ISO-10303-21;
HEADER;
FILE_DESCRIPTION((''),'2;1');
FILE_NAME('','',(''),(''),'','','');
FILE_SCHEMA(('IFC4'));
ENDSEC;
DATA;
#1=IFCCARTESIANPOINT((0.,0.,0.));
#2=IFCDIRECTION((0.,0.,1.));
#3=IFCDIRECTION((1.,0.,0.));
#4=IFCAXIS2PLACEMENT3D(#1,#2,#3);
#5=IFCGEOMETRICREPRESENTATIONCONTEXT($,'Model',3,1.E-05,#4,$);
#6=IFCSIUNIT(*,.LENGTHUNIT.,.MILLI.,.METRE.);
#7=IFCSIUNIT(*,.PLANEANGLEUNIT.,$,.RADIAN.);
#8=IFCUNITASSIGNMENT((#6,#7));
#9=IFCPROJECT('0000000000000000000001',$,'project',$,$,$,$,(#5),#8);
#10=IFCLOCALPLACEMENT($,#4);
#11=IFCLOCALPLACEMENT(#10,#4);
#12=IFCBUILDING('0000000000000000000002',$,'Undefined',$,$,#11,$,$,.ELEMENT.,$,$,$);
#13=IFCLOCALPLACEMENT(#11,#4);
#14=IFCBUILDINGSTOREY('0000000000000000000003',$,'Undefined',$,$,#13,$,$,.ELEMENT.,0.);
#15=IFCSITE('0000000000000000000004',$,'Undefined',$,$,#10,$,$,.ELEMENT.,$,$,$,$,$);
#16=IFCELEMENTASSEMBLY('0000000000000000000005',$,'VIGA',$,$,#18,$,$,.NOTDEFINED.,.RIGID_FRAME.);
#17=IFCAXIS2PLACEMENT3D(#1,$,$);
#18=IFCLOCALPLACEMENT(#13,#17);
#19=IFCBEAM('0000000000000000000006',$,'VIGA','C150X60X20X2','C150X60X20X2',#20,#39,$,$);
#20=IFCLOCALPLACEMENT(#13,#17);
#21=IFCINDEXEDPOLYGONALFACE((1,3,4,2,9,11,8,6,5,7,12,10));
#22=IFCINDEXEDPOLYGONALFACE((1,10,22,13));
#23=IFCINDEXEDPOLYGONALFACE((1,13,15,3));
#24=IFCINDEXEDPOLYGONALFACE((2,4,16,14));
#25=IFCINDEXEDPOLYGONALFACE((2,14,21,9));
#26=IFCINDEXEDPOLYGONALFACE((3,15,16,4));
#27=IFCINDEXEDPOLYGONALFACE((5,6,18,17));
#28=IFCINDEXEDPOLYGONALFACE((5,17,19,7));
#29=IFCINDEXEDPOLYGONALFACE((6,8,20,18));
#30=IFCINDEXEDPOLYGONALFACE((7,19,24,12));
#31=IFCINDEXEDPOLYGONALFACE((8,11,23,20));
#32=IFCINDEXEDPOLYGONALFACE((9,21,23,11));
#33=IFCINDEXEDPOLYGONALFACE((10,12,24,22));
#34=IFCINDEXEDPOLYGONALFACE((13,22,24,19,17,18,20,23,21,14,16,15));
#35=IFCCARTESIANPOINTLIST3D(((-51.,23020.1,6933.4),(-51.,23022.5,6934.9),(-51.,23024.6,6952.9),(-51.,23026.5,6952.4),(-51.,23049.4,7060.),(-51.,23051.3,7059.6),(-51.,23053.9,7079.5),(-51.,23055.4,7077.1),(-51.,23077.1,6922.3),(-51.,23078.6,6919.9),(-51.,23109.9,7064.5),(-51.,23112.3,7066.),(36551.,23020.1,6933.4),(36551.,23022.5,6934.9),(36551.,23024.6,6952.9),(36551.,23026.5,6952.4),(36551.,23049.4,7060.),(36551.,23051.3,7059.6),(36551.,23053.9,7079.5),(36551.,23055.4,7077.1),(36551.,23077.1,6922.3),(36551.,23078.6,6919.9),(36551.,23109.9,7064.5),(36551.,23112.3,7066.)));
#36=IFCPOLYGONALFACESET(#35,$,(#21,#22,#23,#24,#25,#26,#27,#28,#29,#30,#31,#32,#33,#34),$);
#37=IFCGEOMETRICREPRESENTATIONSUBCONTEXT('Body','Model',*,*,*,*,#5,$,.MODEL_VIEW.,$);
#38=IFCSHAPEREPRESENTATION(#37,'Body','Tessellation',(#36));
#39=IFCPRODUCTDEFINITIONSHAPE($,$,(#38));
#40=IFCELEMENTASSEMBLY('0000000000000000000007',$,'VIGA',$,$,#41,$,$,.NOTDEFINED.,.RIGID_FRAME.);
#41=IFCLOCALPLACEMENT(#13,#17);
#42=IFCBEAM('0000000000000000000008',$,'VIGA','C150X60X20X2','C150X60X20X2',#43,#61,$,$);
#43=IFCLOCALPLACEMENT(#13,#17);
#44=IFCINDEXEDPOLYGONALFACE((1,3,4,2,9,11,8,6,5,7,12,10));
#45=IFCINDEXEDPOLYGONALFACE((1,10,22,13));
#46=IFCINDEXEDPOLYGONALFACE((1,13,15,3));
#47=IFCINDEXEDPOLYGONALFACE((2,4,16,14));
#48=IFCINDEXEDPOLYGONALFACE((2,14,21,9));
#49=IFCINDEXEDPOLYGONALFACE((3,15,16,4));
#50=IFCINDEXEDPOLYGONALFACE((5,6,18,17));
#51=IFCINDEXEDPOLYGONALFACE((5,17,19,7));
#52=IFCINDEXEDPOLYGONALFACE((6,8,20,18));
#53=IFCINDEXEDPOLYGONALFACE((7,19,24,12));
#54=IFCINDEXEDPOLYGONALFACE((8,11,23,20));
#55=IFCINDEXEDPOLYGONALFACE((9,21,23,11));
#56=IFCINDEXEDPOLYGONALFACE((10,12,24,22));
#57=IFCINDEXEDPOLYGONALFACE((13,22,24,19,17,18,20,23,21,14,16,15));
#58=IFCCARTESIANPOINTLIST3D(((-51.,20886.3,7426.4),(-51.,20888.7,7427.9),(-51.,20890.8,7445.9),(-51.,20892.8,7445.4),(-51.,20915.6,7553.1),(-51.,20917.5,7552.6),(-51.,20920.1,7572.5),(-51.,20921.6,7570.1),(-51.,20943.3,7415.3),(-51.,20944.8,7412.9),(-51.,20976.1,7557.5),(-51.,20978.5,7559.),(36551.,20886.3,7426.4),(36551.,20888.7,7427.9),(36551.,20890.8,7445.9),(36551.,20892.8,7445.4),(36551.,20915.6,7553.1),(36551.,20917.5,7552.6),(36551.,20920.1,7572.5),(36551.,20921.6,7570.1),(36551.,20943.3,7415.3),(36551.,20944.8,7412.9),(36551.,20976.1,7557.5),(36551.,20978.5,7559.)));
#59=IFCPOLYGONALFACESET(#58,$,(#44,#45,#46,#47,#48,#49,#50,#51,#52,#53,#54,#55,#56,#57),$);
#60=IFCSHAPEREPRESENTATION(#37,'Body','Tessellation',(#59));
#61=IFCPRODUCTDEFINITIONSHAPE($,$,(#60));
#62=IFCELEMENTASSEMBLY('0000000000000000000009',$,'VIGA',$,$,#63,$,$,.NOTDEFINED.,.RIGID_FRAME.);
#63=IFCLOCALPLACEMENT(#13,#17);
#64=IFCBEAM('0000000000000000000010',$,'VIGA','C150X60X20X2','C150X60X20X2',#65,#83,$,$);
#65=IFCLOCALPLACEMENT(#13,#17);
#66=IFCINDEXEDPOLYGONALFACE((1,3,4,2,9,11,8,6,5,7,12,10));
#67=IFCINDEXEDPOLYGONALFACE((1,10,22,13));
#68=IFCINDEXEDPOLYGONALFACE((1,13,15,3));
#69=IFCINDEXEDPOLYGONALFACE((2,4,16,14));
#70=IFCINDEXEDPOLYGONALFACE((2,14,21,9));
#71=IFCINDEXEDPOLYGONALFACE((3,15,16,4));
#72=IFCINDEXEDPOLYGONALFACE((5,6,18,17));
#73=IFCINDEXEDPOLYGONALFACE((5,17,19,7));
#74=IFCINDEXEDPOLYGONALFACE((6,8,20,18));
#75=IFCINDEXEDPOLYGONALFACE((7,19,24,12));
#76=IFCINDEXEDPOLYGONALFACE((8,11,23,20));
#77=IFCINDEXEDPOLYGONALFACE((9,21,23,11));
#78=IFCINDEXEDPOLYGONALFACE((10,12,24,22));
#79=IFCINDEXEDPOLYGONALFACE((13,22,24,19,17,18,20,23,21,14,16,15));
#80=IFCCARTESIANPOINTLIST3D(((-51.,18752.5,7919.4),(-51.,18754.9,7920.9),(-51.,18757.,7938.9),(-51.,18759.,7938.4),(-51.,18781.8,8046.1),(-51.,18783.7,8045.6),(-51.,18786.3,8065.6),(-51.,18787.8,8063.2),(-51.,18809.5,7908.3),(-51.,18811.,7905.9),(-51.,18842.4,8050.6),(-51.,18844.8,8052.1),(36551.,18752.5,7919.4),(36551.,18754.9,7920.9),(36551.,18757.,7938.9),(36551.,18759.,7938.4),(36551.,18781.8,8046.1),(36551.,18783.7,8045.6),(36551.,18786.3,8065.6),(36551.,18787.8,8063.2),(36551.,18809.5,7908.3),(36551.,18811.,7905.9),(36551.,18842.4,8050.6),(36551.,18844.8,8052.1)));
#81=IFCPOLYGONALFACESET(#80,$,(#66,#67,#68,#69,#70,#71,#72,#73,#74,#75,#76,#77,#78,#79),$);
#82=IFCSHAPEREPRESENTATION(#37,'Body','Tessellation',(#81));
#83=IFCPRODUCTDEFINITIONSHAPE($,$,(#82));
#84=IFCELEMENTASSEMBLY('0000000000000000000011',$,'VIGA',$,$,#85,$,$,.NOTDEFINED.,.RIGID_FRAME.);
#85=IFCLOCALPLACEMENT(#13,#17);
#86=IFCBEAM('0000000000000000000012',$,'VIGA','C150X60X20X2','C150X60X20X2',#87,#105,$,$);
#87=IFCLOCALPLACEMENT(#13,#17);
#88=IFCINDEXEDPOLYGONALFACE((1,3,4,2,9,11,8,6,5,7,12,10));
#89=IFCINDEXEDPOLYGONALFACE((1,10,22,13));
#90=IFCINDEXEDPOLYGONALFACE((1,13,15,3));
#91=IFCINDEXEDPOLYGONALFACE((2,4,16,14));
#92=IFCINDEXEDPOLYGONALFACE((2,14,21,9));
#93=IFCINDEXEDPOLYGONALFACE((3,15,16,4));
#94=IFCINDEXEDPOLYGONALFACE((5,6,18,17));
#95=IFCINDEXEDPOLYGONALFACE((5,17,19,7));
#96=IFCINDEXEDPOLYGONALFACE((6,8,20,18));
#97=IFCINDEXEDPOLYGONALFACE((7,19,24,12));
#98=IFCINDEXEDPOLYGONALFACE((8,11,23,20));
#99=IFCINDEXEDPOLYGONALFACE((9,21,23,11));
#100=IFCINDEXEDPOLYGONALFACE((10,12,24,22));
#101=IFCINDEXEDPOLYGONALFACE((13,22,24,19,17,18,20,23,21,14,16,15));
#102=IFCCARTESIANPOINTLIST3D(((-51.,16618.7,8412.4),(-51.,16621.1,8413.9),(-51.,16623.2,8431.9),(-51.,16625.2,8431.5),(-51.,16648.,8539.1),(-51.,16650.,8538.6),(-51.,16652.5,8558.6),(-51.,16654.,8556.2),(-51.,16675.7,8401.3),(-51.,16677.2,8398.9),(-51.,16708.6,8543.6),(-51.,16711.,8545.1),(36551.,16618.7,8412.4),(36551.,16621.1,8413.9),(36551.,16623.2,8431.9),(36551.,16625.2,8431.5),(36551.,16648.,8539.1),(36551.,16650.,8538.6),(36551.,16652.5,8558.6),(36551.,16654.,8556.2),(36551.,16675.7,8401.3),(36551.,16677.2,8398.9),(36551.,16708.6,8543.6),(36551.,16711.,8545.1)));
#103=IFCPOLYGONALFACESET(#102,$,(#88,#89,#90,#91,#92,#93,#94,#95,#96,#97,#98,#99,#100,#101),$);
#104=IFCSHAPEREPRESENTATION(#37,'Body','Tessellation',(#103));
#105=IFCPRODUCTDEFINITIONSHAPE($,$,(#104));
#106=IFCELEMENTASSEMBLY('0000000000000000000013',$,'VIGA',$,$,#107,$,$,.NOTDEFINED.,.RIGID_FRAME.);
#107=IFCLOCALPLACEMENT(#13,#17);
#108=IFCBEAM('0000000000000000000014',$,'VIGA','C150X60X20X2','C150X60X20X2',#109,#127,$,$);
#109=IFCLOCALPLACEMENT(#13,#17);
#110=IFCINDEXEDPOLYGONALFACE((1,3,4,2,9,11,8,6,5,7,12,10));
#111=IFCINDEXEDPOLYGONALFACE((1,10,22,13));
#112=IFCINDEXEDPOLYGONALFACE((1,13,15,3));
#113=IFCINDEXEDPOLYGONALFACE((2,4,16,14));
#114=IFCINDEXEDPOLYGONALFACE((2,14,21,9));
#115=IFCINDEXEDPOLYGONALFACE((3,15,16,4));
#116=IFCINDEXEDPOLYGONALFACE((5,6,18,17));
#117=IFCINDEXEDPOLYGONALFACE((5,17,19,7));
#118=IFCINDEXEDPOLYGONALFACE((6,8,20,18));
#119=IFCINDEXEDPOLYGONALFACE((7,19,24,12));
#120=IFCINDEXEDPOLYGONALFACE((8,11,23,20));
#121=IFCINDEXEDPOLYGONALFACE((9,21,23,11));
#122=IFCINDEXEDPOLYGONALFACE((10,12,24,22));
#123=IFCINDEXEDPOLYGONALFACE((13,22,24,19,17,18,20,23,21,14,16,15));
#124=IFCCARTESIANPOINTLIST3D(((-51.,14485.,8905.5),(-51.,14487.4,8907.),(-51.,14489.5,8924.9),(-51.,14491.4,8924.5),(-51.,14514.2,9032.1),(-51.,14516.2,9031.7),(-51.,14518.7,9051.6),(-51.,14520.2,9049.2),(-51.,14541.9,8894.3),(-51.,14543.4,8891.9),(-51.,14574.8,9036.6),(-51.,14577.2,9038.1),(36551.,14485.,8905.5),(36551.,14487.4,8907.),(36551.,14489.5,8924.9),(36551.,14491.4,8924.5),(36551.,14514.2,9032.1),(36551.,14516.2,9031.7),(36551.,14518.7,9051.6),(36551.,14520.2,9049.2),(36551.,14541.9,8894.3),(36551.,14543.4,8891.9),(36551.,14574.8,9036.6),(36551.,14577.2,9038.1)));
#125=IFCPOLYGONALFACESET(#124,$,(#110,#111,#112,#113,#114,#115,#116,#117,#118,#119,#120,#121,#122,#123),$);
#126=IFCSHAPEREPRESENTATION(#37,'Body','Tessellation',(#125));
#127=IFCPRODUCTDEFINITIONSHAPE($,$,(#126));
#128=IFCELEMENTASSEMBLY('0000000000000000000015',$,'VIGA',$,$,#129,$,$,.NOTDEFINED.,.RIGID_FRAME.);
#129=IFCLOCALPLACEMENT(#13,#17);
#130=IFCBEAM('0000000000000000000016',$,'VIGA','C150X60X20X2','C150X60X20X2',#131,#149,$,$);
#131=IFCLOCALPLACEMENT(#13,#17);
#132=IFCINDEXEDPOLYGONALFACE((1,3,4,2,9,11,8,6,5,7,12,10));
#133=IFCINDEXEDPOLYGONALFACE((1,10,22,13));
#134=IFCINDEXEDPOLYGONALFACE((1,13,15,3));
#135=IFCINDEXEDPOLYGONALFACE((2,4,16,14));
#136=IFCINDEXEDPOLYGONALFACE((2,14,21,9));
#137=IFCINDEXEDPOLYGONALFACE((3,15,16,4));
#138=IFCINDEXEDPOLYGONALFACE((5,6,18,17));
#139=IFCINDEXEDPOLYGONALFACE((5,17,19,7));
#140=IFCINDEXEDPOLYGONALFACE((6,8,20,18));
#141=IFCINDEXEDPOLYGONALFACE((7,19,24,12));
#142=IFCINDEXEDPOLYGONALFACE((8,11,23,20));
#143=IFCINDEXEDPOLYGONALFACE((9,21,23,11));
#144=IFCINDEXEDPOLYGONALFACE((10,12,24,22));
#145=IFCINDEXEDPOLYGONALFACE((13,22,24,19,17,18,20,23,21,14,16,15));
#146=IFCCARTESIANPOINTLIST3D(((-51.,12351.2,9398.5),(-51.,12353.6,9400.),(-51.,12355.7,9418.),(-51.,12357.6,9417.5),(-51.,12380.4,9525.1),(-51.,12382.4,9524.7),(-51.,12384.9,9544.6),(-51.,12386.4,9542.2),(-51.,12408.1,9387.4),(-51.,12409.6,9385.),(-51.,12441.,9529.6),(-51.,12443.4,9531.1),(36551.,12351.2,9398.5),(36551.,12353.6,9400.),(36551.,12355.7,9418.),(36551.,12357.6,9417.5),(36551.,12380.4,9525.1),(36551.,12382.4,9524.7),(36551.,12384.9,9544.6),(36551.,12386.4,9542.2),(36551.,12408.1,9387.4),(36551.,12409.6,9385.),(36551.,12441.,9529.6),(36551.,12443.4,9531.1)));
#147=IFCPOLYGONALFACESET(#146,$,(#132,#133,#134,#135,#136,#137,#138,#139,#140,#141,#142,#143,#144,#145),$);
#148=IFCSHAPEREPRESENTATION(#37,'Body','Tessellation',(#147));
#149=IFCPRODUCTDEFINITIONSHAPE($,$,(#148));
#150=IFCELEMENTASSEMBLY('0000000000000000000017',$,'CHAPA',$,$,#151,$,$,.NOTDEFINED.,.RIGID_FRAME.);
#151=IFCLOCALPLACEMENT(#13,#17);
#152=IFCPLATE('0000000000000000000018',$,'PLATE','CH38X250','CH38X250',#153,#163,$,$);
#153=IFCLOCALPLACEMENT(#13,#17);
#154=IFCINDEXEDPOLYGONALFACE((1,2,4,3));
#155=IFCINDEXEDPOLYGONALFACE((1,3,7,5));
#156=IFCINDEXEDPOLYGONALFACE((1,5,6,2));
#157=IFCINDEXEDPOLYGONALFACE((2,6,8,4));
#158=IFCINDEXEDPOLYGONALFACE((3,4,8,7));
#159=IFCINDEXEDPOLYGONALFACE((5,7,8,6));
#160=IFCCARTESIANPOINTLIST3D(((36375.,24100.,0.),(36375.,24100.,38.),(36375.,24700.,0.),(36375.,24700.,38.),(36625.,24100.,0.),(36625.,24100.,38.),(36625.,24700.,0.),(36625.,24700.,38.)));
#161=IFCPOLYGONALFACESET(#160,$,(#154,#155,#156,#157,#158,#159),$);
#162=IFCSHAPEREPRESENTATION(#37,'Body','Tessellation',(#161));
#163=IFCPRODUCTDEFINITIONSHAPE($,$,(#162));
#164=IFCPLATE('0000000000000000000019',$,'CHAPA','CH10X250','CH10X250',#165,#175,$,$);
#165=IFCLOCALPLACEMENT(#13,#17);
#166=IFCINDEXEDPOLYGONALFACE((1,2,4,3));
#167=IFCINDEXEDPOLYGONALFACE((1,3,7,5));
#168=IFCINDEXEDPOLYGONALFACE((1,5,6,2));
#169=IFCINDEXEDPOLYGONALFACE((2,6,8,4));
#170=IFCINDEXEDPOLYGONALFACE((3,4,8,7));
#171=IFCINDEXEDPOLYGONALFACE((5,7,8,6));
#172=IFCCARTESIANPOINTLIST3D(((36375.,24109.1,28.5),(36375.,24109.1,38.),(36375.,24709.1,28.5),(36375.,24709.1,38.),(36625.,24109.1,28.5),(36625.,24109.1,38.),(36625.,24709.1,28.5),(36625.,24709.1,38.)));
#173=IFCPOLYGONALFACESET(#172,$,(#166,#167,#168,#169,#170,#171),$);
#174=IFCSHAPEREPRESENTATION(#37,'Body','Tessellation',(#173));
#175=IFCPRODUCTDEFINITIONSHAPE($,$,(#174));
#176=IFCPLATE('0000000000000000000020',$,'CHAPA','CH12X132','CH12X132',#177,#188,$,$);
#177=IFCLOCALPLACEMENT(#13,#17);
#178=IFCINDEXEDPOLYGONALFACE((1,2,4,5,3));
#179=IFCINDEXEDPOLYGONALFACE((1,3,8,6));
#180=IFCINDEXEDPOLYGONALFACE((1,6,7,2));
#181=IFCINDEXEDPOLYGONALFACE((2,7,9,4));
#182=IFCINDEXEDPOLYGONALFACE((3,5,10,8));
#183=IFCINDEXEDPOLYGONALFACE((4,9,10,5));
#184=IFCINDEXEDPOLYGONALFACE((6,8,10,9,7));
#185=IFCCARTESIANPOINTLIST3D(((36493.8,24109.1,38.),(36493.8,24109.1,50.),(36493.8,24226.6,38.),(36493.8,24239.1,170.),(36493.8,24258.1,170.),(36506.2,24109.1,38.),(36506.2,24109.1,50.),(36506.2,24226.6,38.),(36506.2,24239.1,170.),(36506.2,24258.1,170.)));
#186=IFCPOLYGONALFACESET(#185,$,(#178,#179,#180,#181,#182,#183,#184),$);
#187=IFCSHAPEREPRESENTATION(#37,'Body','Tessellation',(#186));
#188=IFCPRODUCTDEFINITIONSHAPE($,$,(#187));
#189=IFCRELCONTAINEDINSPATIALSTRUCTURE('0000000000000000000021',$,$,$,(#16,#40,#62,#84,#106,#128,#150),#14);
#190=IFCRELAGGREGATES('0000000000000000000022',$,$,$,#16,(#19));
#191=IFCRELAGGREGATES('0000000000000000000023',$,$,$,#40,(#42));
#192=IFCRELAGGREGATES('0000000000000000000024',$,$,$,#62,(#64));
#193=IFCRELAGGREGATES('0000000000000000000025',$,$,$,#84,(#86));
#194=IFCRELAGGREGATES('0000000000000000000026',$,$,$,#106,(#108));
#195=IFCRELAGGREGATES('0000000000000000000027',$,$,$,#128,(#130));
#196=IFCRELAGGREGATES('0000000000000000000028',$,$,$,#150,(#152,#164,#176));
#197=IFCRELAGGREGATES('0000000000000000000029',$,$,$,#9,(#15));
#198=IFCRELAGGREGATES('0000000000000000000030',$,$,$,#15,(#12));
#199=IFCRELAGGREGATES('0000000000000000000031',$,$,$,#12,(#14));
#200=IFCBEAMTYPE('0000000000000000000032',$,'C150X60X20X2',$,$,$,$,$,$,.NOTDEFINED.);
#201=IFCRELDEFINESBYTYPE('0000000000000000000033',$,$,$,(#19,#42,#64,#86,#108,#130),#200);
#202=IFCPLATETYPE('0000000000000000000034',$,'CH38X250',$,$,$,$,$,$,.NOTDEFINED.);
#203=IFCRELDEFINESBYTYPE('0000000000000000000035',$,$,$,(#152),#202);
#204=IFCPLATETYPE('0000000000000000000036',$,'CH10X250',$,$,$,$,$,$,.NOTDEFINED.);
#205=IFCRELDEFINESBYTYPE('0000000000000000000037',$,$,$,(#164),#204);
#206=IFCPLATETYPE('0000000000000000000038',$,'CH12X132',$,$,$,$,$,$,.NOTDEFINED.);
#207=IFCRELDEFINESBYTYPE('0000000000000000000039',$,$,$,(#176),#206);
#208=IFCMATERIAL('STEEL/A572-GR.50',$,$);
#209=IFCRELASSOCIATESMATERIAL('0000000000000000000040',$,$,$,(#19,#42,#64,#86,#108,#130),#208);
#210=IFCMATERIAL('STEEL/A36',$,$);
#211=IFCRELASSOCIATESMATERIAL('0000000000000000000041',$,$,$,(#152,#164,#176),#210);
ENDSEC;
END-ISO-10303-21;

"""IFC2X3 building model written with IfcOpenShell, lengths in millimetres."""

from ifc_helpers import new_model, si_unit, frame, origin_with_axes, origin_2d_with_axis, place, context, subcontext, project, spatial, polyline, c_section, outline, extrude, material, type_object, element, aggregate, save


model = new_model("IFC2X3")

# Units and contexts
model_context = context("Model", 3, precision=1e-05, world=origin_with_axes())
body_context = subcontext(model_context, "Body", "Model", "MODEL_VIEW")
ifc_project = project(units=[si_unit("LENGTHUNIT", "METRE", prefix="MILLI"), si_unit("PLANEANGLEUNIT", "RADIAN")], contexts=[model_context])

# Site, building, storey
site_placement = place(None, origin_with_axes())
site = spatial("IfcSite", under=ifc_project, at=site_placement, Name="Undefined", CompositionType="ELEMENT")
building_placement = place(site_placement, origin_with_axes())
building = spatial("IfcBuilding", under=site, at=building_placement, Name="Undefined", CompositionType="ELEMENT")
storey_placement = place(building_placement, origin_with_axes())
storey = spatial("IfcBuildingStorey", under=building, at=storey_placement, Name="Undefined", CompositionType="ELEMENT", Elevation=0.0)

# Element assemblies, beams
assembly_1_placement = place(storey_placement, origin_with_axes())
assembly_1 = element("IfcElementAssembly", 1, at=assembly_1_placement, inside=storey, Name="VIGA", AssemblyPlace="NOTDEFINED", PredefinedType="RIGID_FRAME")
ifc_material_1 = material(Name="STEEL/A572-GR.50")
beam_type = type_object("IfcBeamType", Name="C150X60X20X2", PredefinedType="NOTDEFINED")
beam_1_placement = place(assembly_1_placement, frame((36551.0, 23066.2, 6999.7), z_axis=(0.0, -0.225124, -0.97433), x_axis=(-1.0, 0.0, 0.0)))
beam_1 = element("IfcBeam", 2, at=beam_1_placement, type_object=beam_type, material=ifc_material_1, Name="VIGA", Description="C150X60X20X2", ObjectType="C150X60X20X2", context=body_context, shape_type="SweptSolid", body=[
    extrude(c_section(Depth=150.0, Width=60.0, WallThickness=2.0, Girth=20.0, at=origin_2d_with_axis()), frame((36602.0, 0.0, 0.0), z_axis=(-1.0, 0.0, 0.0), x_axis=(0.0, -1.0, 0.0)), (0.0, 0.0, 1.0), 36602.0),
])
assembly_2_placement = place(storey_placement, origin_with_axes())
assembly_2 = element("IfcElementAssembly", 3, at=assembly_2_placement, inside=storey, Name="VIGA", AssemblyPlace="NOTDEFINED", PredefinedType="RIGID_FRAME")
beam_2_placement = place(assembly_2_placement, frame((36551.0, 20932.4, 7492.7), z_axis=(0.0, -0.225124, -0.97433), x_axis=(-1.0, 0.0, 0.0)))
beam_2 = element("IfcBeam", 4, at=beam_2_placement, type_object=beam_type, material=ifc_material_1, Name="VIGA", Description="C150X60X20X2", ObjectType="C150X60X20X2", context=body_context, shape_type="SweptSolid", body=[
    extrude(c_section(Depth=150.0, Width=60.0, WallThickness=2.0, Girth=20.0, at=origin_2d_with_axis()), frame((36602.0, 0.0, 0.0), z_axis=(-1.0, 0.0, 0.0), x_axis=(0.0, -1.0, 0.0)), (0.0, 0.0, 1.0), 36602.0),
])
assembly_3_placement = place(storey_placement, origin_with_axes())
assembly_3 = element("IfcElementAssembly", 5, at=assembly_3_placement, inside=storey, Name="VIGA", AssemblyPlace="NOTDEFINED", PredefinedType="RIGID_FRAME")
beam_3_placement = place(assembly_3_placement, frame((36551.0, 18798.6, 7985.7), z_axis=(0.0, -0.225124, -0.97433), x_axis=(-1.0, 0.0, 0.0)))
beam_3 = element("IfcBeam", 6, at=beam_3_placement, type_object=beam_type, material=ifc_material_1, Name="VIGA", Description="C150X60X20X2", ObjectType="C150X60X20X2", context=body_context, shape_type="SweptSolid", body=[
    extrude(c_section(Depth=150.0, Width=60.0, WallThickness=2.0, Girth=20.0, at=origin_2d_with_axis()), frame((36602.0, 0.0, 0.0), z_axis=(-1.0, 0.0, 0.0), x_axis=(0.0, -1.0, 0.0)), (0.0, 0.0, 1.0), 36602.0),
])
assembly_4_placement = place(storey_placement, origin_with_axes())
assembly_4 = element("IfcElementAssembly", 7, at=assembly_4_placement, inside=storey, Name="VIGA", AssemblyPlace="NOTDEFINED", PredefinedType="RIGID_FRAME")
beam_4_placement = place(assembly_4_placement, frame((36551.0, 16664.9, 8478.8), z_axis=(0.0, -0.225124, -0.97433), x_axis=(-1.0, 0.0, 0.0)))
beam_4 = element("IfcBeam", 8, at=beam_4_placement, type_object=beam_type, material=ifc_material_1, Name="VIGA", Description="C150X60X20X2", ObjectType="C150X60X20X2", context=body_context, shape_type="SweptSolid", body=[
    extrude(c_section(Depth=150.0, Width=60.0, WallThickness=2.0, Girth=20.0, at=origin_2d_with_axis()), frame((36602.0, 0.0, 0.0), z_axis=(-1.0, 0.0, 0.0), x_axis=(0.0, -1.0, 0.0)), (0.0, 0.0, 1.0), 36602.0),
])
assembly_5_placement = place(storey_placement, origin_with_axes())
assembly_5 = element("IfcElementAssembly", 9, at=assembly_5_placement, inside=storey, Name="VIGA", AssemblyPlace="NOTDEFINED", PredefinedType="RIGID_FRAME")
beam_5_placement = place(assembly_5_placement, frame((36551.0, 14531.1, 8971.8), z_axis=(0.0, -0.225124, -0.97433), x_axis=(-1.0, 0.0, 0.0)))
beam_5 = element("IfcBeam", 10, at=beam_5_placement, type_object=beam_type, material=ifc_material_1, Name="VIGA", Description="C150X60X20X2", ObjectType="C150X60X20X2", context=body_context, shape_type="SweptSolid", body=[
    extrude(c_section(Depth=150.0, Width=60.0, WallThickness=2.0, Girth=20.0, at=origin_2d_with_axis()), frame((36602.0, 0.0, 0.0), z_axis=(-1.0, 0.0, 0.0), x_axis=(0.0, -1.0, 0.0)), (0.0, 0.0, 1.0), 36602.0),
])
assembly_6_placement = place(storey_placement, origin_with_axes())
assembly_6 = element("IfcElementAssembly", 11, at=assembly_6_placement, inside=storey, Name="VIGA", AssemblyPlace="NOTDEFINED", PredefinedType="RIGID_FRAME")
beam_6_placement = place(assembly_6_placement, frame((36551.0, 12397.3, 9464.8), z_axis=(0.0, -0.225124, -0.97433), x_axis=(-1.0, 0.0, 0.0)))
beam_6 = element("IfcBeam", 12, at=beam_6_placement, type_object=beam_type, material=ifc_material_1, Name="VIGA", Description="C150X60X20X2", ObjectType="C150X60X20X2", context=body_context, shape_type="SweptSolid", body=[
    extrude(c_section(Depth=150.0, Width=60.0, WallThickness=2.0, Girth=20.0, at=origin_2d_with_axis()), frame((36602.0, 0.0, 0.0), z_axis=(-1.0, 0.0, 0.0), x_axis=(0.0, -1.0, 0.0)), (0.0, 0.0, 1.0), 36602.0),
])

# Element assembly
assembly_7_placement = place(storey_placement, origin_with_axes())
assembly_7 = element("IfcElementAssembly", 13, at=assembly_7_placement, inside=storey, Name="CHAPA", AssemblyPlace="NOTDEFINED", PredefinedType="RIGID_FRAME")

# Plates
ifc_material_2 = material(Name="STEEL/A36")
plate_type_1 = type_object("IfcPlateType", Name="CH38X250", PredefinedType="NOTDEFINED")
plate_1_placement = place(assembly_7_placement, frame((36375.0, 24700.0, 19.0), z_axis=(0.0, 0.0, 1.0), x_axis=(0.0, -1.0, 0.0)))
plate_1 = element("IfcPlate", 14, at=plate_1_placement, type_object=plate_type_1, material=ifc_material_2, Name="PLATE", Description="CH38X250", ObjectType="CH38X250", context=body_context, shape_type="SweptSolid", body=[
    extrude(outline(polyline([(0.0, 0.0), (600.0, 0.0), (600.0, 250.0), (0.0, 250.0), (0.0, 0.0)])), frame((0.0, 0.0, -19.0), z_axis=(0.0, 0.0, 1.0), x_axis=(1.0, 0.0, 0.0)), (0.0, 0.0, 1.0), 38.0),
])
plate_type_2 = type_object("IfcPlateType", Name="CH10X250", PredefinedType="NOTDEFINED")
plate_2_placement = place(assembly_7_placement, frame((36375.0, 24709.1, 33.2), z_axis=(0.0, 0.0, -1.0), x_axis=(1.0, 0.0, 0.0)))
plate_2 = element("IfcPlate", 15, at=plate_2_placement, type_object=plate_type_2, material=ifc_material_2, Name="CHAPA", Description="CH10X250", ObjectType="CH10X250", context=body_context, shape_type="SweptSolid", body=[
    extrude(outline(polyline([(0.0, 0.0), (250.0, 0.0), (250.0, 600.0), (0.0, 600.0), (0.0, 0.0)])), frame((0.0, 0.0, -4.8), z_axis=(0.0, 0.0, 1.0), x_axis=(1.0, 0.0, 0.0)), (0.0, 0.0, 1.0), 9.5),
])
plate_type_3 = type_object("IfcPlateType", Name="CH12X132", PredefinedType="NOTDEFINED")
plate_3_placement = place(assembly_7_placement, frame((36500.0, 24226.6, 38.0), z_axis=(-1.0, 0.0, 0.0), x_axis=(0.0, -1.0, 0.0)))
plate_3 = element("IfcPlate", 16, at=plate_3_placement, type_object=plate_type_3, material=ifc_material_2, Name="CHAPA", Description="CH12X132", ObjectType="CH12X132", context=body_context, shape_type="SweptSolid", body=[
    extrude(outline(polyline([(0.0, 0.0), (117.5, 0.0), (117.5, 12.0), (-12.5, 132.0), (-31.6, 132.0), (0.0, 0.0)])), frame((0.0, 0.0, -6.2), z_axis=(0.0, 0.0, 1.0), x_axis=(1.0, 0.0, 0.0)), (0.0, 0.0, 1.0), 12.5),
])

aggregate(assembly_1, [beam_1])
aggregate(assembly_2, [beam_2])
aggregate(assembly_3, [beam_3])
aggregate(assembly_4, [beam_4])
aggregate(assembly_5, [beam_5])
aggregate(assembly_6, [beam_6])
aggregate(assembly_7, [plate_1, plate_2, plate_3])

save(model, "model.ifc")
